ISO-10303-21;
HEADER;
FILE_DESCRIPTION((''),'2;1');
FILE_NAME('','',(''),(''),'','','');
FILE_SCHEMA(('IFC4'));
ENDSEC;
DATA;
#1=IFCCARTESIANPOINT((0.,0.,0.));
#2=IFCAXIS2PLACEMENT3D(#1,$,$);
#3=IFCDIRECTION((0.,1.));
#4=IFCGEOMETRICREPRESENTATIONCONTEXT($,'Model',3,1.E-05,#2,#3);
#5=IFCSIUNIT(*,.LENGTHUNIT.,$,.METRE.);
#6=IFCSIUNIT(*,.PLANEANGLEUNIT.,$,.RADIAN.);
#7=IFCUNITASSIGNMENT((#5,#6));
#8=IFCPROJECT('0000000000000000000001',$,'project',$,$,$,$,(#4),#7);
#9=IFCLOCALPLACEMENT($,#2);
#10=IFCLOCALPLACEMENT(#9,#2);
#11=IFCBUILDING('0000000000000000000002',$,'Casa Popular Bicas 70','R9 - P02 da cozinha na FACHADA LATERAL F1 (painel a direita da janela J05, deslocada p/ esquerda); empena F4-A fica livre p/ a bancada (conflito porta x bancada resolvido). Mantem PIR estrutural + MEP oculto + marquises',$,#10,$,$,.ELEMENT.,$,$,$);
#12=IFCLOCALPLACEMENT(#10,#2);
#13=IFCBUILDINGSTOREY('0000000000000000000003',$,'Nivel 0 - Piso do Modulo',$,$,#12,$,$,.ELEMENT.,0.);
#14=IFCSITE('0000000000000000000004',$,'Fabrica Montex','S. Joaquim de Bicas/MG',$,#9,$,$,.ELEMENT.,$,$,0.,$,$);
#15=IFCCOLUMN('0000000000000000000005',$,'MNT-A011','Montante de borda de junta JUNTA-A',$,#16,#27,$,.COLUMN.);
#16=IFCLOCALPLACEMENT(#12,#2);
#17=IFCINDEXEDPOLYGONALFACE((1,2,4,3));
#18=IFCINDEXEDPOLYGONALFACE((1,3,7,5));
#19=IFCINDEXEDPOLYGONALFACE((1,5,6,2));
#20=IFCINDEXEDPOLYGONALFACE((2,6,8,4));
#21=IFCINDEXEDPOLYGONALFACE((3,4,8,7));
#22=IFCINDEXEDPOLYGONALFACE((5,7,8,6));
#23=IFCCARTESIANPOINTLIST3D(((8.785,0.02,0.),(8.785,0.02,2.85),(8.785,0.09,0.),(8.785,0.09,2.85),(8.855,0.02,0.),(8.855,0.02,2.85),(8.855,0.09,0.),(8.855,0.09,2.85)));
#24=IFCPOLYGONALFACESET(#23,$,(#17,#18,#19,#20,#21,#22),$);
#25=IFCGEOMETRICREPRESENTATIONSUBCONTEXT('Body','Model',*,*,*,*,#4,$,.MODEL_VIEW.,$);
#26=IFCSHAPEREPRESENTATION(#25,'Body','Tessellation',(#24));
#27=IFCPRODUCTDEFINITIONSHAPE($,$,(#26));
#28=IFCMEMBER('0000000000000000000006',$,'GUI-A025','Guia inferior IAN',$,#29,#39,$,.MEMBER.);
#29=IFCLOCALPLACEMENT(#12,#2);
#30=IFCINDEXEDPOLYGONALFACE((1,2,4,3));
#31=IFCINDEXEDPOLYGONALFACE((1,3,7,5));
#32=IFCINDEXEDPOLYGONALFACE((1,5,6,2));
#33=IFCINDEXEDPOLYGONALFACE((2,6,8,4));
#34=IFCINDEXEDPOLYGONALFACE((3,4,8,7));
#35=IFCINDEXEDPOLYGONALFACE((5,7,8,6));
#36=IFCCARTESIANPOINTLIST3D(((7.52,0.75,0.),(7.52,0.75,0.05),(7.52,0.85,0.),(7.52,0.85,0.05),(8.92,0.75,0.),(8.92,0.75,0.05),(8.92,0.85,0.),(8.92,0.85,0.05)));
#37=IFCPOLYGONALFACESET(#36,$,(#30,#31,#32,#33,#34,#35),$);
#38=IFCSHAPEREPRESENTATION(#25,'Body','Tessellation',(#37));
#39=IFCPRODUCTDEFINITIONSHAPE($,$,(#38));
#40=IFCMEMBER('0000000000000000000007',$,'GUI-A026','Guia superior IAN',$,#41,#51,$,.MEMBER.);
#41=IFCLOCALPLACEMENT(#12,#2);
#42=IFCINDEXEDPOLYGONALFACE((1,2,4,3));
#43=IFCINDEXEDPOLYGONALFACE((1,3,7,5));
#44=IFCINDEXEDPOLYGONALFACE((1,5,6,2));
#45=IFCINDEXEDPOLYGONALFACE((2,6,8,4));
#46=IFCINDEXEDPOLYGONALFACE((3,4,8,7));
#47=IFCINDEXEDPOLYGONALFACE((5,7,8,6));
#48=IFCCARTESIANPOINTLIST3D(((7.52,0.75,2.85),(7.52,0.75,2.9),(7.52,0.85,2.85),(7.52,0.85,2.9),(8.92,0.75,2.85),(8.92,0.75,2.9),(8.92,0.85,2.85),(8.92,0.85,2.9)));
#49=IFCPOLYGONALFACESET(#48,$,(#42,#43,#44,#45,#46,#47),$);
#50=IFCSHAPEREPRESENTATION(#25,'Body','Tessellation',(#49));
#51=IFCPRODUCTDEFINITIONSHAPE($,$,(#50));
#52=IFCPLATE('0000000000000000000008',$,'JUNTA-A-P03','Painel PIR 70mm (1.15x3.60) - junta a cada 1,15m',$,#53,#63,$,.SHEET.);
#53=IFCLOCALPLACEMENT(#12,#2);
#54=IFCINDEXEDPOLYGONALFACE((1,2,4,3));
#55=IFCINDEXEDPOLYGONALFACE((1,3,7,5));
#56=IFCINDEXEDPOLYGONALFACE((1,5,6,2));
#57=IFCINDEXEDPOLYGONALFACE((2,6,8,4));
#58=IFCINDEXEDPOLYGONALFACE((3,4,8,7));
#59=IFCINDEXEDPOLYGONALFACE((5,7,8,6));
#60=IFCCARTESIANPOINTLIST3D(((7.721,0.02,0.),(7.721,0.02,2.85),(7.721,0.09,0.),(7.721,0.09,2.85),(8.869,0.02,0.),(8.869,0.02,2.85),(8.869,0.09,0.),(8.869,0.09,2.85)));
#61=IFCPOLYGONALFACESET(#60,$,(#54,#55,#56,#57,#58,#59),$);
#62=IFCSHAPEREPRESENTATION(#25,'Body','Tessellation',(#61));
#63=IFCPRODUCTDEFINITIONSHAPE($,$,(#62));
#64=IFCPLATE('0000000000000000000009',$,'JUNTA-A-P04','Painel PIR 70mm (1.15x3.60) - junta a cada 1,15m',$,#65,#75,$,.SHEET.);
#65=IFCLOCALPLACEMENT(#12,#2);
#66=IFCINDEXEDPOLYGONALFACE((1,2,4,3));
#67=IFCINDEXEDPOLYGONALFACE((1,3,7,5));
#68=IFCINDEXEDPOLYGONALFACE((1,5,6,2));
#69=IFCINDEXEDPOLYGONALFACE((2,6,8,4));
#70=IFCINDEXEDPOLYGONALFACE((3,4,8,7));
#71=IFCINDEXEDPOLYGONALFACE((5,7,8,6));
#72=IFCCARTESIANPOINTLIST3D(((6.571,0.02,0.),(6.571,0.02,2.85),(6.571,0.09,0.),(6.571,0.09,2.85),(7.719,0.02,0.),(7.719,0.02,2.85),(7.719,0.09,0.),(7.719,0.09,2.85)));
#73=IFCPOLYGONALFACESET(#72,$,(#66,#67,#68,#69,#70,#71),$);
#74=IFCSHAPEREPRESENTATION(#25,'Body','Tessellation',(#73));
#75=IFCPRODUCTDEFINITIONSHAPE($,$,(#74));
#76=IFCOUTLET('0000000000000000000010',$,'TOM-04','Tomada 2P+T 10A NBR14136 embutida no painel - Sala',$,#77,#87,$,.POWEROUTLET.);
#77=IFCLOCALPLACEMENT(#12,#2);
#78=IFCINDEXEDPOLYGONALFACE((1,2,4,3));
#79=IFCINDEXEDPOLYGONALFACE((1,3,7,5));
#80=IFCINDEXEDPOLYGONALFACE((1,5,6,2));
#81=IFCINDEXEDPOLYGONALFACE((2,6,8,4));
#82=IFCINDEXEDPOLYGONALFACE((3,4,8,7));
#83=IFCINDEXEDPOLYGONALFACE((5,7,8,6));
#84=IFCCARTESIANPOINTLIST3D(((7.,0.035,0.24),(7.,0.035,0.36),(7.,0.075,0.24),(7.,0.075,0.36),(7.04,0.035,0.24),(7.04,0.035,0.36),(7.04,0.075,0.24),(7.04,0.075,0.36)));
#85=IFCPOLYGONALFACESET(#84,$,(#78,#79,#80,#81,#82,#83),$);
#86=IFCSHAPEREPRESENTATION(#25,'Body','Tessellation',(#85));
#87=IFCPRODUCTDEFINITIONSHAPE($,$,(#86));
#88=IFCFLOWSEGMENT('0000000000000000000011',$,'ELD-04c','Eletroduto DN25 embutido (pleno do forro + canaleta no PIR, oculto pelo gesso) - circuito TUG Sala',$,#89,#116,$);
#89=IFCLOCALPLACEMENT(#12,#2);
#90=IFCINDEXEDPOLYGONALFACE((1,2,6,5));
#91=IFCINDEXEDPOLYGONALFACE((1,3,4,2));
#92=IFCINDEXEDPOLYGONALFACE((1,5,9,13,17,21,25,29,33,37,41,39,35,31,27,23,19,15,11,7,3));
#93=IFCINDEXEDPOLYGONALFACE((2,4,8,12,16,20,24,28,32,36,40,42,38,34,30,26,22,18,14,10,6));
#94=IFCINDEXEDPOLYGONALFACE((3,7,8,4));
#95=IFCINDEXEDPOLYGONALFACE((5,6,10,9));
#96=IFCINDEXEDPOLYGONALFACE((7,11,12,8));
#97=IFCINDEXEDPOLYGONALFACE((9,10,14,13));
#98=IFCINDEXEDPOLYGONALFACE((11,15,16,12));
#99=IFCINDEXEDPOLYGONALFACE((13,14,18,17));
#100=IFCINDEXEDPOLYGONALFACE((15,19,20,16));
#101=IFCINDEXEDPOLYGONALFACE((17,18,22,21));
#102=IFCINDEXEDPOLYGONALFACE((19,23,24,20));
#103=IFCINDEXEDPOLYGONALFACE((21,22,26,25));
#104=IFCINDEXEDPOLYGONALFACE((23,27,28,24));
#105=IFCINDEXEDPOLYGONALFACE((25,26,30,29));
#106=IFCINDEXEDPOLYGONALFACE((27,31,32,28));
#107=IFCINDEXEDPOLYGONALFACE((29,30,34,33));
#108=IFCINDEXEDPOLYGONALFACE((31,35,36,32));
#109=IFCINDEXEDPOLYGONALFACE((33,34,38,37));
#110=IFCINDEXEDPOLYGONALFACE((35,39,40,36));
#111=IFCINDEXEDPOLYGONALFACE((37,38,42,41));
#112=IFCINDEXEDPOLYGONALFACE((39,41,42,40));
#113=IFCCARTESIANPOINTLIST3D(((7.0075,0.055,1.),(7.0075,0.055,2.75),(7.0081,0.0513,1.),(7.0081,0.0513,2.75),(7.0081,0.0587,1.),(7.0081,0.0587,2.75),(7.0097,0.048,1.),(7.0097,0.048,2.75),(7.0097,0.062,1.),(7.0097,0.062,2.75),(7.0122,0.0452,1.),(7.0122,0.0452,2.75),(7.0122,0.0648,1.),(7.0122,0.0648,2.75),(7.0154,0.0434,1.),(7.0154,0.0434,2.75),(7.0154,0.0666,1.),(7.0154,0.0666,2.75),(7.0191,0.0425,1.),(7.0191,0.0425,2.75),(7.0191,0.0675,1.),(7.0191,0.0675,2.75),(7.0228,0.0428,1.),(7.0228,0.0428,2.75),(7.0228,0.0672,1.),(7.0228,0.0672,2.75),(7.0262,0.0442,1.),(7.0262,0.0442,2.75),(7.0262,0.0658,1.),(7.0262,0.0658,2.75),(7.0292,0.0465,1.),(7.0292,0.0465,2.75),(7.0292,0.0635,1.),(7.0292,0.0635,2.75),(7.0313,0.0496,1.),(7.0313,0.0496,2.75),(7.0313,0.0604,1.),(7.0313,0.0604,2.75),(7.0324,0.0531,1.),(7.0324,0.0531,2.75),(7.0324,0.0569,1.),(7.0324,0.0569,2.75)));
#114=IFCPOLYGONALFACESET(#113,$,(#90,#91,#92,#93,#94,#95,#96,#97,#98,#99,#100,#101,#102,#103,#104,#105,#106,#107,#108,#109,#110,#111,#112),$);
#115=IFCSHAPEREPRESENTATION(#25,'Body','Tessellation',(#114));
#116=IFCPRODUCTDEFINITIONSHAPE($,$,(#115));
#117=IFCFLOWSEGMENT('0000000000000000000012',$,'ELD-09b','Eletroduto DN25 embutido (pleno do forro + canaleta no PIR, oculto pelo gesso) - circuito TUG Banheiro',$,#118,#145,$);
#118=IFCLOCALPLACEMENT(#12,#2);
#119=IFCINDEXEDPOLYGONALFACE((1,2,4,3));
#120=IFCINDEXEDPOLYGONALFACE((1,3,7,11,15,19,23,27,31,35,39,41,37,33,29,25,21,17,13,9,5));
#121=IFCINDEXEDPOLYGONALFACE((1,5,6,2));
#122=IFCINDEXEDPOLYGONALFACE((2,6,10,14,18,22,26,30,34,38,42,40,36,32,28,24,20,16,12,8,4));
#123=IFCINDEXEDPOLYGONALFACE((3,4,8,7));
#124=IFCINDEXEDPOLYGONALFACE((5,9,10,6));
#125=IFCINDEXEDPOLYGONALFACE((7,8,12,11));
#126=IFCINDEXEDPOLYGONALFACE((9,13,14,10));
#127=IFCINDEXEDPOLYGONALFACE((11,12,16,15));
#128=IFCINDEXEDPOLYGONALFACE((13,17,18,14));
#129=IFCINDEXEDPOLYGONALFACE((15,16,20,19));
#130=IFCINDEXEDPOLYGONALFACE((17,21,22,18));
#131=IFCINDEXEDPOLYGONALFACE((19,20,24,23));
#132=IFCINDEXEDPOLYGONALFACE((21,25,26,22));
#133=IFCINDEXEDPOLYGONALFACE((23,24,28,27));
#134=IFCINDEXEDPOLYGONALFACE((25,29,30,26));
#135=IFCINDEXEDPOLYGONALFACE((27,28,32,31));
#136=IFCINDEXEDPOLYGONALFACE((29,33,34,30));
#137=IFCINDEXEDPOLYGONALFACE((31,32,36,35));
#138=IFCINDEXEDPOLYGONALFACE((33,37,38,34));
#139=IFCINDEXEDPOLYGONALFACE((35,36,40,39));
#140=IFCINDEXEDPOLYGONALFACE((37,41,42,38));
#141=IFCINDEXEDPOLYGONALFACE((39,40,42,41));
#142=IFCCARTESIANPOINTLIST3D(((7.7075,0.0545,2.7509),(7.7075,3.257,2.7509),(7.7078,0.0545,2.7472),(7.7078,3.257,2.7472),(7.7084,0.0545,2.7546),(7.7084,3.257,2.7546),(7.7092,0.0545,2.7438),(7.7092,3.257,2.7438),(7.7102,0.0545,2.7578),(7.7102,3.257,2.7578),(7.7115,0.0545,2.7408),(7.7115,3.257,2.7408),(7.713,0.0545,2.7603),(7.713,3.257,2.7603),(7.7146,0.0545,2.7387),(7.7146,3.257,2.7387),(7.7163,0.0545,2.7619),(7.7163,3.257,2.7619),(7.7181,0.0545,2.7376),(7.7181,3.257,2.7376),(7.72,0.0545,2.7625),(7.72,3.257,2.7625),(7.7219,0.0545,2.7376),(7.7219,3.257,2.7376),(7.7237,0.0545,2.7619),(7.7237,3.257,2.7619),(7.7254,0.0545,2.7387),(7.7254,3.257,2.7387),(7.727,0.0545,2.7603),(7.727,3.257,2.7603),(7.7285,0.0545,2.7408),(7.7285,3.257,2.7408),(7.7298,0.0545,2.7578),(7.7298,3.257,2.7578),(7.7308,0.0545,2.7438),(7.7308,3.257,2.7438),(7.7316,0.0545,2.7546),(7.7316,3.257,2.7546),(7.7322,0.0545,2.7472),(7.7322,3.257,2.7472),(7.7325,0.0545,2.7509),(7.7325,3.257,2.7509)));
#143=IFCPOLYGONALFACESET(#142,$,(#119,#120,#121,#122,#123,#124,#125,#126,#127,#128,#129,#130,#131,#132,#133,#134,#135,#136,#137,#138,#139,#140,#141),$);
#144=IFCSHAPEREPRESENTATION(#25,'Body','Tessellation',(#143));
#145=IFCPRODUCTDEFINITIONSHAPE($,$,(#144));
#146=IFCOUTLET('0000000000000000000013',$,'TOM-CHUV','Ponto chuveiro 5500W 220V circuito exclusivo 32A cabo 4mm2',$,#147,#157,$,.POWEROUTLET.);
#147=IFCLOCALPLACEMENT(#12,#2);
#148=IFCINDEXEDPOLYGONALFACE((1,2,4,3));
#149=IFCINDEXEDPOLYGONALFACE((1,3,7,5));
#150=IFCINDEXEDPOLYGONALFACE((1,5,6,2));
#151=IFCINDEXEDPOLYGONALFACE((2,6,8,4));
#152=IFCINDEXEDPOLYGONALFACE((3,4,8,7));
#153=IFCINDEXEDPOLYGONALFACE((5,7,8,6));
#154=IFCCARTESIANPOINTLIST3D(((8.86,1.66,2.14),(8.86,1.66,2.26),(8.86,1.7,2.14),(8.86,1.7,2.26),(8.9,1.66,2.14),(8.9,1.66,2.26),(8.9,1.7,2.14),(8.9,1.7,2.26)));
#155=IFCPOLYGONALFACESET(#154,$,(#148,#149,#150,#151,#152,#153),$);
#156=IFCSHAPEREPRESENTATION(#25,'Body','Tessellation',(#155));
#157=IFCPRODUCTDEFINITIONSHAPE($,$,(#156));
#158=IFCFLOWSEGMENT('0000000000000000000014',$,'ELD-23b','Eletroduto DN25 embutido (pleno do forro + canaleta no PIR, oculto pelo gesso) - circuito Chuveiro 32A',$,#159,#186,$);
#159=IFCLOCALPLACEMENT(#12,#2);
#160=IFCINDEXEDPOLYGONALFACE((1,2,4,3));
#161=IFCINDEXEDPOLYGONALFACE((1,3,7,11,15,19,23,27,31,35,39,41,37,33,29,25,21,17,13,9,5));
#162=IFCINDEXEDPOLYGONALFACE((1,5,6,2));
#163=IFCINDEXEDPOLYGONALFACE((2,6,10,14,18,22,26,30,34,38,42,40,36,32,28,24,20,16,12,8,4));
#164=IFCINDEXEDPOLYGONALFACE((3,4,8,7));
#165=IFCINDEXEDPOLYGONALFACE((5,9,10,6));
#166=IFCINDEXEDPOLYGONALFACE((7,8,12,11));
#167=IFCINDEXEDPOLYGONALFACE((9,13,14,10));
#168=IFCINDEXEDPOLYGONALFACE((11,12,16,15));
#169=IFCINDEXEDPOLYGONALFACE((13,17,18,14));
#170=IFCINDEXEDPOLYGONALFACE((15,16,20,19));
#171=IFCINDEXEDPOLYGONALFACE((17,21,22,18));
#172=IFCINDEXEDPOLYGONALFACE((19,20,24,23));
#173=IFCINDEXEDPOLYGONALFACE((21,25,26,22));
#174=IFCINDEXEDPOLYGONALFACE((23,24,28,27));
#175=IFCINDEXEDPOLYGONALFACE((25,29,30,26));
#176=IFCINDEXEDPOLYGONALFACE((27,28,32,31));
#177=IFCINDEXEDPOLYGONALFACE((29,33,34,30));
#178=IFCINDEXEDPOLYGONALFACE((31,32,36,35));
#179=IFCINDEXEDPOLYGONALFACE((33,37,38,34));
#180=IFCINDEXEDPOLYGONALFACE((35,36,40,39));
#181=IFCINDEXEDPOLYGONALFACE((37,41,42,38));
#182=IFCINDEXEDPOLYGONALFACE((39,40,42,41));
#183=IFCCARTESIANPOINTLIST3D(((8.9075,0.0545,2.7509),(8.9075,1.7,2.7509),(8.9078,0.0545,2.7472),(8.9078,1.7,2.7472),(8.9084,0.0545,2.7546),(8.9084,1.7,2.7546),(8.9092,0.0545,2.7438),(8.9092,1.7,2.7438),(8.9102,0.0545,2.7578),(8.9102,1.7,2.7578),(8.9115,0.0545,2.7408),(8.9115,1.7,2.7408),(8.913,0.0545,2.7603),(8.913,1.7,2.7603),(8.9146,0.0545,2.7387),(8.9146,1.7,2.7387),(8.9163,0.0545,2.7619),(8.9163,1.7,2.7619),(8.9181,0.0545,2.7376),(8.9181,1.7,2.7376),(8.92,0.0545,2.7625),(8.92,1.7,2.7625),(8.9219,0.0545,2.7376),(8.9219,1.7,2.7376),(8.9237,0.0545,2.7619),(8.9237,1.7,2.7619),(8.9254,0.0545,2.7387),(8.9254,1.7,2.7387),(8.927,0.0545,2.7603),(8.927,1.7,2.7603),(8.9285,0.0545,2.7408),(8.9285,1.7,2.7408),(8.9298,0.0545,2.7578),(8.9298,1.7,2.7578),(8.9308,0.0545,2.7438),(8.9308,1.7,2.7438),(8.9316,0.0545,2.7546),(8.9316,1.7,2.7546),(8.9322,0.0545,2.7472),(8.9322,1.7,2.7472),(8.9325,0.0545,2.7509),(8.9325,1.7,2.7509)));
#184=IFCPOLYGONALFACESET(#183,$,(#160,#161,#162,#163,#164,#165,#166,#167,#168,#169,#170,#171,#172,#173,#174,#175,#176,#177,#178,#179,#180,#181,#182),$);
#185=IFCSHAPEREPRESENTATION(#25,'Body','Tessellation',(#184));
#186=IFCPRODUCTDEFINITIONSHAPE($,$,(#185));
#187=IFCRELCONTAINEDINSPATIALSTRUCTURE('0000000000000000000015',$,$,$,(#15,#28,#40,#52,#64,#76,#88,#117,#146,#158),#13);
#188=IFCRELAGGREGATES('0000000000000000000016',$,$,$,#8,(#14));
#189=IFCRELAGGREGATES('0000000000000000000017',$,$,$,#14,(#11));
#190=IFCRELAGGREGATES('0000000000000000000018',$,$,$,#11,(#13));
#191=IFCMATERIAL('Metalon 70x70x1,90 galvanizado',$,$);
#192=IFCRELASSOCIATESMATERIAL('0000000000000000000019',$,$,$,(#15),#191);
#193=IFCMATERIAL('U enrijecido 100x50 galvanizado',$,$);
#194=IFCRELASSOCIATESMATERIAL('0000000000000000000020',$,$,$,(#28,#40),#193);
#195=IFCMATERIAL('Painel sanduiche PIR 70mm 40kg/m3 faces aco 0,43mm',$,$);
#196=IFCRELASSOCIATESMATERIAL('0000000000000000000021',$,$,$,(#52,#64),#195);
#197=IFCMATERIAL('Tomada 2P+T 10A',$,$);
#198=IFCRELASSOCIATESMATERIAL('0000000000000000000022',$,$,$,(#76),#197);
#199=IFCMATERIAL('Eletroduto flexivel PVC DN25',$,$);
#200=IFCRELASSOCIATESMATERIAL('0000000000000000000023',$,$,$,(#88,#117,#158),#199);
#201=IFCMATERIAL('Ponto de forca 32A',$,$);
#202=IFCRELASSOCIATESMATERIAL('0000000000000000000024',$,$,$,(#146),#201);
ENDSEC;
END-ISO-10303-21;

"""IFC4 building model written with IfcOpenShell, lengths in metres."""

from ifc_helpers import new_model, si_unit, direction, frame, frame_2d, origin, origin_2d, place, context, subcontext, project, spatial, rectangle, circle, extrude, material, element, save


model = new_model("IFC4")

# Units and contexts
model_context = context("Model", 3, precision=1e-05, world=origin(), true_north=direction((0.0, 1.0)))
body_context = subcontext(model_context, "Body", "Model", "MODEL_VIEW")
ifc_project = project(units=[si_unit("LENGTHUNIT", "METRE"), si_unit("PLANEANGLEUNIT", "RADIAN")], contexts=[model_context])

# Site, building, storey
site_placement = place(None, origin())
site = spatial("IfcSite", under=ifc_project, at=site_placement, Name="Fabrica Montex", Description="S. Joaquim de Bicas/MG", CompositionType="ELEMENT", RefElevation=0.0)
building_placement = place(site_placement, origin())
building = spatial("IfcBuilding", under=site, at=building_placement, Name="Casa Popular Bicas 70", Description="R9 - P02 da cozinha na FACHADA LATERAL F1 (painel a direita da janela J05, deslocada p/ esquerda); empena F4-A fica livre p/ a bancada (conflito porta x bancada resolvido). Mantem PIR estrutural + MEP oculto + marquises", CompositionType="ELEMENT")
storey_placement = place(building_placement, origin())
storey = spatial("IfcBuildingStorey", under=building, at=storey_placement, Name="Nivel 0 - Piso do Modulo", CompositionType="ELEMENT", Elevation=0.0)

# Column
ifc_material_1 = material(Name="Metalon 70x70x1,90 galvanizado")
column_placement = place(None, frame((8.82, 0.055, 0.0), z_axis=(0.0, 0.0, 1.0), x_axis=(-1.0, 0.0, 0.0)))
element("IfcColumn", 1, at=column_placement, inside=storey, material=ifc_material_1, Name="MNT-A011", Description="Montante de borda de junta JUNTA-A", PredefinedType="COLUMN", context=body_context, shape_type="SweptSolid", body=[
    extrude(rectangle(XDim=0.07, YDim=0.07, at=origin_2d()), origin(), (0.0, 0.0, 1.0), 2.85),
])

# Members
ifc_material_2 = material(Name="U enrijecido 100x50 galvanizado")
for number, where, z_axis, x_axis, name, description in (
    (2, (8.92, 0.8, 0.025), (-1.0, 0.0, 0.0), (0.0, 0.0, 1.0), "GUI-A025", "Guia inferior IAN"),
    (3, (8.92, 0.8, 2.875), (-1.0, 0.0, 0.0), (0.0, 0.0, 1.0), "GUI-A026", "Guia superior IAN"),
):
    element("IfcMember", number, at=place(None, frame(where, z_axis=z_axis, x_axis=x_axis)), inside=storey, material=ifc_material_2, Name=name, Description=description, PredefinedType="MEMBER", context=body_context, shape_type="SweptSolid", body=[
        extrude(rectangle(XDim=0.05, YDim=0.1, at=origin_2d()), origin(), (0.0, 0.0, 1.0), 1.4),
    ])

# Plates
ifc_material_3 = material(Name="Painel sanduiche PIR 70mm 40kg/m3 faces aco 0,43mm")
for number, where, z_axis, x_axis, name in (
    (4, (8.869, 0.055, 0.0), (0.0, 0.0, 1.0), (-1.0, 0.0, 0.0), "JUNTA-A-P03"),
    (5, (7.719, 0.055, 0.0), (0.0, 0.0, 1.0), (-1.0, 0.0, 0.0), "JUNTA-A-P04"),
):
    element("IfcPlate", number, at=place(None, frame(where, z_axis=z_axis, x_axis=x_axis)), inside=storey, material=ifc_material_3, Name=name, Description="Painel PIR 70mm (1.15x3.60) - junta a cada 1,15m", PredefinedType="SHEET", context=body_context, shape_type="SweptSolid", body=[
        extrude(rectangle(XDim=1.148, YDim=0.07, at=frame_2d((0.574, 0.0))), origin(), (0.0, 0.0, 1.0), 2.85),
    ])

# Outlet
ifc_material_4 = material(Name="Tomada 2P+T 10A")
outlet_1_placement = place(None, frame((7.04, 0.075, 0.24), z_axis=(0.0, 0.0, 1.0), x_axis=(-1.0, 0.0, 0.0)))
element("IfcOutlet", 6, at=outlet_1_placement, inside=storey, material=ifc_material_4, Name="TOM-04", Description="Tomada 2P+T 10A NBR14136 embutida no painel - Sala", PredefinedType="POWEROUTLET", context=body_context, shape_type="SweptSolid", body=[
    extrude(rectangle(XDim=0.04, YDim=0.04, at=frame_2d((0.02, 0.02))), origin(), (0.0, 0.0, 1.0), 0.12),
])

# Flow segments
ifc_material_5 = material(Name="Eletroduto flexivel PVC DN25")
flow_segment_1_placement = place(None, frame((7.02, 0.055, 2.75), z_axis=(0.0, 0.0, -1.0), x_axis=(-1.0, 0.0, 0.0)))
element("IfcFlowSegment", 7, at=flow_segment_1_placement, inside=storey, material=ifc_material_5, Name="ELD-04c", Description="Eletroduto DN25 embutido (pleno do forro + canaleta no PIR, oculto pelo gesso) - circuito TUG Sala", context=body_context, shape_type="SweptSolid", body=[
    extrude(circle(Radius=0.0125, at=origin_2d()), origin(), (0.0, 0.0, 1.0), 1.75),
])
flow_segment_2_placement = place(None, frame((7.72, 0.0545, 2.75), z_axis=(0.0, 1.0, 0.0), x_axis=(0.0, 0.0, 1.0)))
element("IfcFlowSegment", 8, at=flow_segment_2_placement, inside=storey, material=ifc_material_5, Name="ELD-09b", Description="Eletroduto DN25 embutido (pleno do forro + canaleta no PIR, oculto pelo gesso) - circuito TUG Banheiro", context=body_context, shape_type="SweptSolid", body=[
    extrude(circle(Radius=0.0125, at=origin_2d()), origin(), (0.0, 0.0, 1.0), 3.2025),
])

# Outlet
ifc_material_6 = material(Name="Ponto de forca 32A")
outlet_2_placement = place(None, frame((8.9, 1.7, 2.14), z_axis=(0.0, 0.0, 1.0), x_axis=(-1.0, 0.0, 0.0)))
element("IfcOutlet", 9, at=outlet_2_placement, inside=storey, material=ifc_material_6, Name="TOM-CHUV", Description="Ponto chuveiro 5500W 220V circuito exclusivo 32A cabo 4mm2", PredefinedType="POWEROUTLET", context=body_context, shape_type="SweptSolid", body=[
    extrude(rectangle(XDim=0.04, YDim=0.04, at=frame_2d((0.02, 0.02))), origin(), (0.0, 0.0, 1.0), 0.12),
])

# Flow segment
flow_segment_3_placement = place(None, frame((8.92, 0.0545, 2.75), z_axis=(0.0, 1.0, 0.0), x_axis=(0.0, 0.0, 1.0)))
element("IfcFlowSegment", 10, at=flow_segment_3_placement, inside=storey, material=ifc_material_5, Name="ELD-23b", Description="Eletroduto DN25 embutido (pleno do forro + canaleta no PIR, oculto pelo gesso) - circuito Chuveiro 32A", context=body_context, shape_type="SweptSolid", body=[
    extrude(circle(Radius=0.0125, at=origin_2d()), origin(), (0.0, 0.0, 1.0), 1.6455),
])

save(model, "model.ifc")
